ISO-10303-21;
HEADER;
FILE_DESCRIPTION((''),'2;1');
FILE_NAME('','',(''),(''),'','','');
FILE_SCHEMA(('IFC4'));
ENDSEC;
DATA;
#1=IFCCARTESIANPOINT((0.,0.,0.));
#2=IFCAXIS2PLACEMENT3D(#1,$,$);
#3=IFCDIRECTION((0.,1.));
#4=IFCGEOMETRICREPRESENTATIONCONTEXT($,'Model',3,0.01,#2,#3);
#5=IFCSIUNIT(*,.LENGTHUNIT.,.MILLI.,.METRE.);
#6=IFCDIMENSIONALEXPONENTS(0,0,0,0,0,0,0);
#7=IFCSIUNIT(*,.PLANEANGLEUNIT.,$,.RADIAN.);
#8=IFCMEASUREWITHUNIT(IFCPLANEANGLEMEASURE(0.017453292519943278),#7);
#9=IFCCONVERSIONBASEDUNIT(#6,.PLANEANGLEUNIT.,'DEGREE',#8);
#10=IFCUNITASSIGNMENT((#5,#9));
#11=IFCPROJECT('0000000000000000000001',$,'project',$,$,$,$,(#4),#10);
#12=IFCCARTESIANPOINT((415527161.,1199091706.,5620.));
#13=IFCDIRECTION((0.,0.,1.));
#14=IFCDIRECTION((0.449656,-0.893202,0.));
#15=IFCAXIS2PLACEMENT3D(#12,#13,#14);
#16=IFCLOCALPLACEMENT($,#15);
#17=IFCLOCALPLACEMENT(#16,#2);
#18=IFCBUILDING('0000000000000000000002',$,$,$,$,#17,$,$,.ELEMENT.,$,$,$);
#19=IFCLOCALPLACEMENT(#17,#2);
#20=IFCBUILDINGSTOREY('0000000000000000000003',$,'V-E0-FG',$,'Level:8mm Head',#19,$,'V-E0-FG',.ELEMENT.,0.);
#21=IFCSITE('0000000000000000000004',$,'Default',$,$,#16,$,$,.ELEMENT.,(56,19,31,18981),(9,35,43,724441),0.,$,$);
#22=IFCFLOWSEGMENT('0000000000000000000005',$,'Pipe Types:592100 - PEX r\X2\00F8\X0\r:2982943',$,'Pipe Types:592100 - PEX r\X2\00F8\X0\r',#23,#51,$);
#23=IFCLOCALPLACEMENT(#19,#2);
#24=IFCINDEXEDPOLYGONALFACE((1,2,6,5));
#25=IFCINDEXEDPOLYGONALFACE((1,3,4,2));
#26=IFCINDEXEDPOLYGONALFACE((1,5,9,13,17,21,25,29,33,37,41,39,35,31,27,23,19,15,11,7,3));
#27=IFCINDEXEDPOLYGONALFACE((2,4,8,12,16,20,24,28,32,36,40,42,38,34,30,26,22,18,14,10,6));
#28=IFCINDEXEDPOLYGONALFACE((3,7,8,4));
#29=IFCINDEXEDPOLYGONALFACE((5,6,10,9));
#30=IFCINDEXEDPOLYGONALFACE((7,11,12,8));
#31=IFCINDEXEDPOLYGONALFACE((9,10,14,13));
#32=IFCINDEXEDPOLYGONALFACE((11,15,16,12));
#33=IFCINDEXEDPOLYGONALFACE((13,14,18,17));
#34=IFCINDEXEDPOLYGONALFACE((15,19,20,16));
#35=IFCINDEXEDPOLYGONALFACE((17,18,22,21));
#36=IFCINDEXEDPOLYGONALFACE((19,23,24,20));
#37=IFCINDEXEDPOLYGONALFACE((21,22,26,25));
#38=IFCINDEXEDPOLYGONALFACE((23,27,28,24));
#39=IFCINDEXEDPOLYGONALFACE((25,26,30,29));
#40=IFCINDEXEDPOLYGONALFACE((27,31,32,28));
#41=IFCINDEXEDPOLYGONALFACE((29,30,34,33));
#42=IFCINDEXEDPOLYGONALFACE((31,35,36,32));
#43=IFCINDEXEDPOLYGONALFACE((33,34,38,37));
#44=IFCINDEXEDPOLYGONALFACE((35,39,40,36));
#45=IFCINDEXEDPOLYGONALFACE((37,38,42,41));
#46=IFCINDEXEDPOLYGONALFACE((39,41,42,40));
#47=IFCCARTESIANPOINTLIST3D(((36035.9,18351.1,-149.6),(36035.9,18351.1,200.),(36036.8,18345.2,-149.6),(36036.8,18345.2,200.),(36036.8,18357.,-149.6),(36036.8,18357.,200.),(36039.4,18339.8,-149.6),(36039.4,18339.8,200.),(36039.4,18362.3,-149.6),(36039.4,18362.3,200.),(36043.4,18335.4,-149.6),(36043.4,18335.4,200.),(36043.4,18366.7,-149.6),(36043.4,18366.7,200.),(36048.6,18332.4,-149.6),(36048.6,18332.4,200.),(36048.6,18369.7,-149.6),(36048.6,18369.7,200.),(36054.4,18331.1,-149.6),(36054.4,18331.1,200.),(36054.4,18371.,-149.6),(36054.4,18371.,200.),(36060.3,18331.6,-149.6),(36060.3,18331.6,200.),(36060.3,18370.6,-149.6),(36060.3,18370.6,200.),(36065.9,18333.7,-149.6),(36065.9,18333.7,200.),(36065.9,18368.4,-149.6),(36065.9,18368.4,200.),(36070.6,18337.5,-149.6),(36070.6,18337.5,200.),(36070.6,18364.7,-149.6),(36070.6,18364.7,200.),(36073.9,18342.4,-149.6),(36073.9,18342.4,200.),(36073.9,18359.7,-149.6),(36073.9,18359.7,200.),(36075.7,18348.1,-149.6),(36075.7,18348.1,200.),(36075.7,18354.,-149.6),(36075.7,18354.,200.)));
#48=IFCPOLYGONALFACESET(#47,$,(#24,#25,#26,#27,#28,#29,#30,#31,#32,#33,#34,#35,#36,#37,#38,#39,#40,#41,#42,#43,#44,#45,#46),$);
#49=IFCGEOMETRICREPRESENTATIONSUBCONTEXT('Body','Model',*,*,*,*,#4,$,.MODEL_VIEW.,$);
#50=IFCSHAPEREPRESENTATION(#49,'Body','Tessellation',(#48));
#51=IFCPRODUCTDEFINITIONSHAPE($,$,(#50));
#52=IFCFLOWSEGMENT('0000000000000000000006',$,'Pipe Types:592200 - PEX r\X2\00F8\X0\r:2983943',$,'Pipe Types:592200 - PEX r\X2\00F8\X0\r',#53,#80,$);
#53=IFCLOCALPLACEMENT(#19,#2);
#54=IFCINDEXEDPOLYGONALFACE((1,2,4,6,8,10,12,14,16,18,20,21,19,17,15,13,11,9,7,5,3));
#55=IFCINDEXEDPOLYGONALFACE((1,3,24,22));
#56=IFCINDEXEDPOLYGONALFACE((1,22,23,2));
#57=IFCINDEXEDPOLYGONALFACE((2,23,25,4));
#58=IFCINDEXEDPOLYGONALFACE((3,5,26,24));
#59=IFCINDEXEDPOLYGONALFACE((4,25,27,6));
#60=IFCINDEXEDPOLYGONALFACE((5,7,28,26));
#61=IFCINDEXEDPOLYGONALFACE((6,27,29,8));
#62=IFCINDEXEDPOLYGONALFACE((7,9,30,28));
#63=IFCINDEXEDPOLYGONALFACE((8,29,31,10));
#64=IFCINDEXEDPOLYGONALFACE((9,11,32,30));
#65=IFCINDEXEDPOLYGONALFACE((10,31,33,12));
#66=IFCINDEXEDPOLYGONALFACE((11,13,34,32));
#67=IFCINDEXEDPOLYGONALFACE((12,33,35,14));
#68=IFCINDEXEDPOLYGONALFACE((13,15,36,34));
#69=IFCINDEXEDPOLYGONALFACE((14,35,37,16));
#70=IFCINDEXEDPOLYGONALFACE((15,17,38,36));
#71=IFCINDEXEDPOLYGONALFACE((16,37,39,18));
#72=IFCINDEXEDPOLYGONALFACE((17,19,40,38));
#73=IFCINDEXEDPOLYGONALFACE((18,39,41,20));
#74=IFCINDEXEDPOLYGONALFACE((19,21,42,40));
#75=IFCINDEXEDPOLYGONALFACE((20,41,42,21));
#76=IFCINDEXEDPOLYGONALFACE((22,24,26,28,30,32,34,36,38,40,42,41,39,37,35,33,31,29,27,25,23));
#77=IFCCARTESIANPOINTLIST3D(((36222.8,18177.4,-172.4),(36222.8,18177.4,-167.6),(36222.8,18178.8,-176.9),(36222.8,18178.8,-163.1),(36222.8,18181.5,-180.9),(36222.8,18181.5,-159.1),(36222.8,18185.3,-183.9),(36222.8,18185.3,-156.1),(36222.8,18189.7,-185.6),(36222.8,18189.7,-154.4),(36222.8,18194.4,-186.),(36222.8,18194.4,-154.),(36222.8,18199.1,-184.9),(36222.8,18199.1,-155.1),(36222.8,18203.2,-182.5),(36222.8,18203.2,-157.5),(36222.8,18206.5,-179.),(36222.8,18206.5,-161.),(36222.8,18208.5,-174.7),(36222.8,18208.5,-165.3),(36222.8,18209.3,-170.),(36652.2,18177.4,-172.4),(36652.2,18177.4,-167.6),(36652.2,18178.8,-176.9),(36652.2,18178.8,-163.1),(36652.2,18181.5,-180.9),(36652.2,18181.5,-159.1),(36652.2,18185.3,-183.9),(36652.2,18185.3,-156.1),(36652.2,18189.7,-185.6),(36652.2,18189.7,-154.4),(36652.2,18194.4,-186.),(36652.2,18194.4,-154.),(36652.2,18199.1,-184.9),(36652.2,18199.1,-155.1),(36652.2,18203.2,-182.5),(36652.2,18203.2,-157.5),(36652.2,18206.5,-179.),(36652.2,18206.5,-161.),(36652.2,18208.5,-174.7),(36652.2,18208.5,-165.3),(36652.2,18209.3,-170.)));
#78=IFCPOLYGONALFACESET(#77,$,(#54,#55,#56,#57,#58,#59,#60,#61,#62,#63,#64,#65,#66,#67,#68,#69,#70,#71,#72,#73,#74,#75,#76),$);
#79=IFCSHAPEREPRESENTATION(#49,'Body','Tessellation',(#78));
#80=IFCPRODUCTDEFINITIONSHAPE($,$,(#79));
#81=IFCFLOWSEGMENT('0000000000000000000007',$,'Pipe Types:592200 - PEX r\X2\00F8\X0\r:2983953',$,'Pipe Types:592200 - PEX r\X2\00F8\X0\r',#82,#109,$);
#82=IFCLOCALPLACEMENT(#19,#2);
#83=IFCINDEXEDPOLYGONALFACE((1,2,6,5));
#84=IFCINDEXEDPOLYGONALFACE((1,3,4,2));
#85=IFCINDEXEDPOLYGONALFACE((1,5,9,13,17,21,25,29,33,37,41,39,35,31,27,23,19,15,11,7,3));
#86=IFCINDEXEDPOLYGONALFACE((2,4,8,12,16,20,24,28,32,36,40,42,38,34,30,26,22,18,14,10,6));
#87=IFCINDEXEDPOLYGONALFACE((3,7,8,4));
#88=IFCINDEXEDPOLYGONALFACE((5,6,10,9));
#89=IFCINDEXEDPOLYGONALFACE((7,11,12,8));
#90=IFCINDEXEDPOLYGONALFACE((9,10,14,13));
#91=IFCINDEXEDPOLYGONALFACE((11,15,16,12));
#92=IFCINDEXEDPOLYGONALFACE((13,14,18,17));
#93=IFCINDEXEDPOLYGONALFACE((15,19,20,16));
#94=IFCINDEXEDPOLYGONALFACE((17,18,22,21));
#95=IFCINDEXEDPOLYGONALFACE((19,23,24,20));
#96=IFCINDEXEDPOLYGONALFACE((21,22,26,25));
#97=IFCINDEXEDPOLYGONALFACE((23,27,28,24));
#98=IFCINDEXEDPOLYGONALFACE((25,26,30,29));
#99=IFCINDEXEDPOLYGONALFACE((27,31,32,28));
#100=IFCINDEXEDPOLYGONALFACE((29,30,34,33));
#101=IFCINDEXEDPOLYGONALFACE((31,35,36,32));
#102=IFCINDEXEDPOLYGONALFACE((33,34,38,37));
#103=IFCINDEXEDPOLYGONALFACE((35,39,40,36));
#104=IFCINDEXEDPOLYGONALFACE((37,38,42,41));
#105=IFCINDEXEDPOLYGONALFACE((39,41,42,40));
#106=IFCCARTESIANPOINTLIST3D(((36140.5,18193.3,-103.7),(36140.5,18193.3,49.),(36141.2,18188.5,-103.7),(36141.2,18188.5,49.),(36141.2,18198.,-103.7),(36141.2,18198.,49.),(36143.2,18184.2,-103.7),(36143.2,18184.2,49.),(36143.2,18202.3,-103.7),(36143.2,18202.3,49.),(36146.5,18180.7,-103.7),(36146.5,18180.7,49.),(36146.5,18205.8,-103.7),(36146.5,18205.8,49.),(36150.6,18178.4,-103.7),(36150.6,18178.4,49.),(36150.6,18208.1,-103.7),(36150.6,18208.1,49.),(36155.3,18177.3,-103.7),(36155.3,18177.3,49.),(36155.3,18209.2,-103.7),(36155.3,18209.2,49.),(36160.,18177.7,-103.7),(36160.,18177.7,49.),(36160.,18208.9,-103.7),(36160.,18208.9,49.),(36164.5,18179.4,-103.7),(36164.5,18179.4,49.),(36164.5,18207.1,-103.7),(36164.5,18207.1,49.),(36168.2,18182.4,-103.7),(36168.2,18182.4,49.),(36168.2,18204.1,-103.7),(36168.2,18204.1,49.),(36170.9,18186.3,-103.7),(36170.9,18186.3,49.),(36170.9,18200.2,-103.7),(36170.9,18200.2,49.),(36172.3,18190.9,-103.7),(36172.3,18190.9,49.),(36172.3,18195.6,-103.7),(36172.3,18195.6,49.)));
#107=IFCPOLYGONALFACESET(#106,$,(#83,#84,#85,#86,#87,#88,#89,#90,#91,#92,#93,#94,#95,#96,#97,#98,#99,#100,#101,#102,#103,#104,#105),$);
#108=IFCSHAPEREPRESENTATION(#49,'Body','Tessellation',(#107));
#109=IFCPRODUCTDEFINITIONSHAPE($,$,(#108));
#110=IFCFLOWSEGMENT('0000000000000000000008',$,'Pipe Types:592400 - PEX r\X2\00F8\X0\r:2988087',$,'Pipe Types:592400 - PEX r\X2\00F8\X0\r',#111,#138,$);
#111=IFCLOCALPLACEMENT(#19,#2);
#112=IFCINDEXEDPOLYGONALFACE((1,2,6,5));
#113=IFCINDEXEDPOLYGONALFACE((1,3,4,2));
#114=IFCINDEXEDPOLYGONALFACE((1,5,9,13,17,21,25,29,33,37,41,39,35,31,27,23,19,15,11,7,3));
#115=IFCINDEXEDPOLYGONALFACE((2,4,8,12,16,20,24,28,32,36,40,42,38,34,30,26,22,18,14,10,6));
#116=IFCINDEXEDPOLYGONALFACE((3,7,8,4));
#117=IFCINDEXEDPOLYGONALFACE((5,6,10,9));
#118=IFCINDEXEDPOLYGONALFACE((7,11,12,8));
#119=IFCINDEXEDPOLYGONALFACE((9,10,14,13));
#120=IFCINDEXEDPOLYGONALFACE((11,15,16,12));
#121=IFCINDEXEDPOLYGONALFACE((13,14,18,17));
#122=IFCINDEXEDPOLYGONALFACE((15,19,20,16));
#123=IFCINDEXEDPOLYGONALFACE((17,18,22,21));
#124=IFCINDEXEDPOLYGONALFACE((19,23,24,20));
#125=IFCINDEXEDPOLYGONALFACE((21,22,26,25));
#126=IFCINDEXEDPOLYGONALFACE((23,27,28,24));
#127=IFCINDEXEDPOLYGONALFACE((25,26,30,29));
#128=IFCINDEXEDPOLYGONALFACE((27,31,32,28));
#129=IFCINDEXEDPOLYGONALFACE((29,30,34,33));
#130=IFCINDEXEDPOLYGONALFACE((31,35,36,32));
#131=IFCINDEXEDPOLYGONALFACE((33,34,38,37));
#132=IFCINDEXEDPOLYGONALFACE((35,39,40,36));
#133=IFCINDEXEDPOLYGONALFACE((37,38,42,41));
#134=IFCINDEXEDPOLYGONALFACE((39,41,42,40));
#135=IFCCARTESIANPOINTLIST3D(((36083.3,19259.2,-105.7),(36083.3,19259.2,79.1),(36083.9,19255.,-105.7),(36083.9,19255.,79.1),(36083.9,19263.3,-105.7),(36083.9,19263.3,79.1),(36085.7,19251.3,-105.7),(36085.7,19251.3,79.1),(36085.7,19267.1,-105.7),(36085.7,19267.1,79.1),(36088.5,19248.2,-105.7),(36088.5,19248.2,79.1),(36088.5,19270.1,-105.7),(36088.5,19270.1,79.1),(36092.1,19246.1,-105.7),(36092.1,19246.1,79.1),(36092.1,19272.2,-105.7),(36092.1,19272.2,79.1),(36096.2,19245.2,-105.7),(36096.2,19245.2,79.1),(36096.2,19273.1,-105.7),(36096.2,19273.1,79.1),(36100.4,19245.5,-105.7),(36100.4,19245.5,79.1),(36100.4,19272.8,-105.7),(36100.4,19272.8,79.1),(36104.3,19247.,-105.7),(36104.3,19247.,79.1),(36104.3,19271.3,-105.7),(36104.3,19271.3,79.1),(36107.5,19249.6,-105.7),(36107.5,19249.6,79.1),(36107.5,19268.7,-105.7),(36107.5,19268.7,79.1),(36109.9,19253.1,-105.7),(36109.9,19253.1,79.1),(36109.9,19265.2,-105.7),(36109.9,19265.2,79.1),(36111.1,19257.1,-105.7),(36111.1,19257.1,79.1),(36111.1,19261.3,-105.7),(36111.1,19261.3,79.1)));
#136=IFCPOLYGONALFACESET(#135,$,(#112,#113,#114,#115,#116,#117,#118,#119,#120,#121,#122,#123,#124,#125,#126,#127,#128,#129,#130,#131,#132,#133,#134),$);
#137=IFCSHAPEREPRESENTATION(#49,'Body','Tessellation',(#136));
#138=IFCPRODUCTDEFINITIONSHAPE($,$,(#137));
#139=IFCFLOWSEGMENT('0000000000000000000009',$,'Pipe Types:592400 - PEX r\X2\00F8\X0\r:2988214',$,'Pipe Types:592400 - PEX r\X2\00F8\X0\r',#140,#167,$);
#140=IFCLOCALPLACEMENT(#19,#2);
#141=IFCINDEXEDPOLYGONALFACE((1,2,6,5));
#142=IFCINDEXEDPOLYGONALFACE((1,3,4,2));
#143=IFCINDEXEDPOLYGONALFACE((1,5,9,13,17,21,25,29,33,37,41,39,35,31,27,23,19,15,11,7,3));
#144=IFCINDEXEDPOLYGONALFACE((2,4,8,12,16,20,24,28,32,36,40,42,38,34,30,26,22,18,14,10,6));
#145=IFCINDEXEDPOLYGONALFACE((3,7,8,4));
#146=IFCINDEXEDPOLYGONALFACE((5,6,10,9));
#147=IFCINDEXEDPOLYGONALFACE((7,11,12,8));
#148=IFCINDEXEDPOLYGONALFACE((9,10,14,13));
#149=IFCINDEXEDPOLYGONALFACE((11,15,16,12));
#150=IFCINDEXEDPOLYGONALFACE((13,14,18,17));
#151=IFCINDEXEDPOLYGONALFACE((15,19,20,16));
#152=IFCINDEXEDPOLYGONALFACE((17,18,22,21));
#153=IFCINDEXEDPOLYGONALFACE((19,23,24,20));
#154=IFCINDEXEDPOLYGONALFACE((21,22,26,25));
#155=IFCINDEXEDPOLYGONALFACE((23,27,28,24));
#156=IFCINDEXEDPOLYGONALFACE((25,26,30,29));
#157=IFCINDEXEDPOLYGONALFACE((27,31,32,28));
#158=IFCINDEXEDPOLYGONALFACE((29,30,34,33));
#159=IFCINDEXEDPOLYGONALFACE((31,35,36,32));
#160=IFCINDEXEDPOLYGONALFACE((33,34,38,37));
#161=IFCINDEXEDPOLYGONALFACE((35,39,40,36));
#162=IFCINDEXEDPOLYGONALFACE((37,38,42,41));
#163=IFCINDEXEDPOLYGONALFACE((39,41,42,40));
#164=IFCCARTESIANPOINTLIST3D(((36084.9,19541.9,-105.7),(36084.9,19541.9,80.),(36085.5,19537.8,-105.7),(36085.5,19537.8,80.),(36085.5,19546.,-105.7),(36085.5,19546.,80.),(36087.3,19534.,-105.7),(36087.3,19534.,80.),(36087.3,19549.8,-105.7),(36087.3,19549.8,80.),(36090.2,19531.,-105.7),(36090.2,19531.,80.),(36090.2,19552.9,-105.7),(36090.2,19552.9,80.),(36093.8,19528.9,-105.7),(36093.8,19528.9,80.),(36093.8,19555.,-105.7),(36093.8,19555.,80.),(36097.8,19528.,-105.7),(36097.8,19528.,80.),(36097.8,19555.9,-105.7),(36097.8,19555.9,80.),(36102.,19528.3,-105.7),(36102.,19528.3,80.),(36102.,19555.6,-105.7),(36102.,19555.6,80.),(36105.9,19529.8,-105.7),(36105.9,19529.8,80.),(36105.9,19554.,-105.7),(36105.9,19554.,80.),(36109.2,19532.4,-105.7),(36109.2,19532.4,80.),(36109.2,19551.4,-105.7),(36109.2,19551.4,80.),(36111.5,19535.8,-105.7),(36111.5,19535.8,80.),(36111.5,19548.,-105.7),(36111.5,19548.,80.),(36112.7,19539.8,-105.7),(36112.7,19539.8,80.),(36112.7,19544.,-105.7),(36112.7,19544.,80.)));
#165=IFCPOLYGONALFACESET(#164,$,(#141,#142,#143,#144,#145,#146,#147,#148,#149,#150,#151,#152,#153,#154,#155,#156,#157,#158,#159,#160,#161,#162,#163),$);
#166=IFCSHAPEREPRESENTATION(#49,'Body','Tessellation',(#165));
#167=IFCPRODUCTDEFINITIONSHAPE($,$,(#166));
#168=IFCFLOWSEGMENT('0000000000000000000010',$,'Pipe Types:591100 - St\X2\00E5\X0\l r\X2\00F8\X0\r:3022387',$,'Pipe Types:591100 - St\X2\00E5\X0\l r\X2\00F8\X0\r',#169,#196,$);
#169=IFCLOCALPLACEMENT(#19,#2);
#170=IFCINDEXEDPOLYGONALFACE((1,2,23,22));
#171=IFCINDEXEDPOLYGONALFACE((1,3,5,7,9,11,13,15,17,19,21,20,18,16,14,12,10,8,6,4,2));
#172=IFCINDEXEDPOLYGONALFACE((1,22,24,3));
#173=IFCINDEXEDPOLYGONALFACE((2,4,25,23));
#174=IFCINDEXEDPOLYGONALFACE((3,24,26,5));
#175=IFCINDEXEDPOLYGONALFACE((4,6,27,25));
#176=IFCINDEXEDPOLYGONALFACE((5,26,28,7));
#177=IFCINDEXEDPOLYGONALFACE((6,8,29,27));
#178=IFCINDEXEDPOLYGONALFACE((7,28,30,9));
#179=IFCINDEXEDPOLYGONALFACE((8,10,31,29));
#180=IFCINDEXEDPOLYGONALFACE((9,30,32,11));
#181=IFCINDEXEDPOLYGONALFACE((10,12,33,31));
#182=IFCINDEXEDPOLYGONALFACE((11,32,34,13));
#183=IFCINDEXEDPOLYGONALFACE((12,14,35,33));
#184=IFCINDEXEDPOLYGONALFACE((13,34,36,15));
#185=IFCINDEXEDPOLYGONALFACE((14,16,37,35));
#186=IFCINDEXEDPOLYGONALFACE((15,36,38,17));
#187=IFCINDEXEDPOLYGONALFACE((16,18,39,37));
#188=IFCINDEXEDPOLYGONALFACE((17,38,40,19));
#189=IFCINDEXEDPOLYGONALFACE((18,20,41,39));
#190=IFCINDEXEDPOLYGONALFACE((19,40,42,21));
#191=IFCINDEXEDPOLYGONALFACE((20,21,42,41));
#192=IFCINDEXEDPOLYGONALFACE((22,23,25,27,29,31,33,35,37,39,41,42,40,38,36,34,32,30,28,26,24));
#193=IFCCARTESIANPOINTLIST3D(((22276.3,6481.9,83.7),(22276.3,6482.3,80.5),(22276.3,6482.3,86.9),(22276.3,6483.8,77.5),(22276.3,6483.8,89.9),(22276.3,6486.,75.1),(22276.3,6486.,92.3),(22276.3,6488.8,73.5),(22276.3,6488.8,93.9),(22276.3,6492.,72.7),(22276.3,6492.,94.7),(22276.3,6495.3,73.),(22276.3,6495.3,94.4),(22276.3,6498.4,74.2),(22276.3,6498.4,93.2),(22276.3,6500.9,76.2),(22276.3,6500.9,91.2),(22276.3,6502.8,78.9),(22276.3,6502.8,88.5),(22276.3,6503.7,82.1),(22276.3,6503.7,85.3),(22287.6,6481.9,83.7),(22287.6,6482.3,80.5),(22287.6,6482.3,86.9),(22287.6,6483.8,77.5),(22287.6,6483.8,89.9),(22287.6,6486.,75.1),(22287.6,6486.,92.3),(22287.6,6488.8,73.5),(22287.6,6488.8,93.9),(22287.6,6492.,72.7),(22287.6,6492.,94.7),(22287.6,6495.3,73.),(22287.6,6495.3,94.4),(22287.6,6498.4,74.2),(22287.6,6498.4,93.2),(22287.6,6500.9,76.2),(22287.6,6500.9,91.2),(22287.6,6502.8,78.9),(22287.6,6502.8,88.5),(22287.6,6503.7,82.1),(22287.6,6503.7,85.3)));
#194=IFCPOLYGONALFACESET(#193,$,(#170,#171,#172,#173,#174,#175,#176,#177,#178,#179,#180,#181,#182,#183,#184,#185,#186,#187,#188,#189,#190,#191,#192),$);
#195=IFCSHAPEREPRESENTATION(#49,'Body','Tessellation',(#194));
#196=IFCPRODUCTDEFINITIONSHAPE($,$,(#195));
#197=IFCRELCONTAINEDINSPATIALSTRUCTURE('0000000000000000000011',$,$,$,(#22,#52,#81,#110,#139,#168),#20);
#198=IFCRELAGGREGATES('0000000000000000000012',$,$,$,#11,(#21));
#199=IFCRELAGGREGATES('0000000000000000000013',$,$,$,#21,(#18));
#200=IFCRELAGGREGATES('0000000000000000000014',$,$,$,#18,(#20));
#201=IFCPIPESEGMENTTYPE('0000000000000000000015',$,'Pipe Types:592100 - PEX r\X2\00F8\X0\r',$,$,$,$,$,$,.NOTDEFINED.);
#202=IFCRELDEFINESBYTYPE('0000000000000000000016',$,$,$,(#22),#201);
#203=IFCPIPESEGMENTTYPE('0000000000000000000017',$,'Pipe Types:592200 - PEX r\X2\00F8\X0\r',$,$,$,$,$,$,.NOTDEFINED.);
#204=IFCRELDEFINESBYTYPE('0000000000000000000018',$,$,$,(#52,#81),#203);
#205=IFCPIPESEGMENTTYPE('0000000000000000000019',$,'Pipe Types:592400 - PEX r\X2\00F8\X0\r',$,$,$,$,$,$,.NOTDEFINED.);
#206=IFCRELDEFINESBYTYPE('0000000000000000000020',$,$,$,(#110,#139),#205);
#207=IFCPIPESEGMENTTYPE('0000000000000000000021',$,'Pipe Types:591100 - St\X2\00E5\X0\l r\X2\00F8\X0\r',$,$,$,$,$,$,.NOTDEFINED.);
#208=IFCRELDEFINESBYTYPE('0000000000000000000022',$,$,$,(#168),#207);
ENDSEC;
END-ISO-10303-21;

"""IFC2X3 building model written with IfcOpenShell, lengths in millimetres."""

from ifc_helpers import new_model, entity, si_unit, converted_unit, direction, frame, frame_2d, origin, origin_2d_with_axis, place, context, subcontext, project, spatial, circle, extrude, type_object, element, save


model = new_model("IFC2X3")

# Units and contexts
model_context = context("Model", 3, precision=0.01, world=origin(), true_north=direction((0.0, 1.0)))
body_context = subcontext(model_context, "Body", "Model", "MODEL_VIEW")
ifc_project = project(units=[si_unit("LENGTHUNIT", "METRE", prefix="MILLI"), converted_unit("PLANEANGLEUNIT", "DEGREE", entity("IfcPlaneAngleMeasure", 0.017453292519943278), si_unit("PLANEANGLEUNIT", "RADIAN"), dimensions=[0, 0, 0, 0, 0, 0, 0])], contexts=[model_context])

# Site, building, storey
site_placement = place(None, frame((415527161.0, 1199091706.0, 5620.0), z_axis=(0.0, 0.0, 1.0), x_axis=(0.449656, -0.893202, 0.0)))
site = spatial("IfcSite", under=ifc_project, at=site_placement, Name="Default", CompositionType="ELEMENT", RefLatitude=(56, 19, 31, 18981), RefLongitude=(9, 35, 43, 724441), RefElevation=0.0)
building_placement = place(site_placement, origin())
building = spatial("IfcBuilding", under=site, at=building_placement, CompositionType="ELEMENT")
storey_placement = place(building_placement, origin())
storey = spatial("IfcBuildingStorey", under=building, at=storey_placement, Name="V-E0-FG", ObjectType="Level:8mm Head", LongName="V-E0-FG", CompositionType="ELEMENT", Elevation=0.0)

# Flow segments
pipe_segment_type_1 = type_object("IfcPipeSegmentType", Name="Pipe Types:592100 - PEX rør", PredefinedType="NOTDEFINED")
flow_segment_1_placement = place(storey_placement, origin())
element("IfcFlowSegment", 1, at=flow_segment_1_placement, inside=storey, type_object=pipe_segment_type_1, Name="Pipe Types:592100 - PEX rør:2982943", ObjectType="Pipe Types:592100 - PEX rør", context=body_context, shape_type="SweptSolid", body=[
    extrude(circle(Radius=20.0, at=origin_2d_with_axis()), frame((36055.9, 18351.1, -149.6), z_axis=(0.0, 0.0, 1.0), x_axis=(-1.0, 0.0, 0.0)), (0.0, 0.0, 1.0), 349.6),
])
pipe_segment_type_2 = type_object("IfcPipeSegmentType", Name="Pipe Types:592200 - PEX rør", PredefinedType="NOTDEFINED")
flow_segment_2_placement = place(storey_placement, origin())
element("IfcFlowSegment", 2, at=flow_segment_2_placement, inside=storey, type_object=pipe_segment_type_2, Name="Pipe Types:592200 - PEX rør:2983943", ObjectType="Pipe Types:592200 - PEX rør", context=body_context, shape_type="SweptSolid", body=[
    extrude(circle(Radius=16.0, at=frame_2d((0.0, 0.0), x_axis=(1.0, 0.0))), frame((36222.8, 18193.3, -170.0), z_axis=(1.0, 0.0, 0.0), x_axis=(0.0, 1.0, 0.0)), (0.0, 0.0, 1.0), 429.5),
])
flow_segment_3_placement = place(storey_placement, origin())
element("IfcFlowSegment", 3, at=flow_segment_3_placement, inside=storey, type_object=pipe_segment_type_2, Name="Pipe Types:592200 - PEX rør:2983953", ObjectType="Pipe Types:592200 - PEX rør", context=body_context, shape_type="SweptSolid", body=[
    extrude(circle(Radius=16.0, at=origin_2d_with_axis()), frame((36156.5, 18193.3, -103.7), z_axis=(0.0, 0.0, 1.0), x_axis=(-1.0, 0.0, 0.0)), (0.0, 0.0, 1.0), 152.7),
])
pipe_segment_type_3 = type_object("IfcPipeSegmentType", Name="Pipe Types:592400 - PEX rør", PredefinedType="NOTDEFINED")
flow_segment_4_placement = place(storey_placement, origin())
element("IfcFlowSegment", 4, at=flow_segment_4_placement, inside=storey, type_object=pipe_segment_type_3, Name="Pipe Types:592400 - PEX rør:2988087", ObjectType="Pipe Types:592400 - PEX rør", context=body_context, shape_type="SweptSolid", body=[
    extrude(circle(Radius=14.0, at=origin_2d_with_axis()), frame((36097.3, 19259.2, -105.7), z_axis=(0.0, 0.0, 1.0), x_axis=(-1.0, 0.0, 0.0)), (0.0, 0.0, 1.0), 184.8),
])
flow_segment_5_placement = place(storey_placement, origin())
element("IfcFlowSegment", 5, at=flow_segment_5_placement, inside=storey, type_object=pipe_segment_type_3, Name="Pipe Types:592400 - PEX rør:2988214", ObjectType="Pipe Types:592400 - PEX rør", context=body_context, shape_type="SweptSolid", body=[
    extrude(circle(Radius=14.0, at=origin_2d_with_axis()), frame((36098.9, 19541.9, -105.7), z_axis=(0.0, 0.0, 1.0), x_axis=(-1.0, 0.0, 0.0)), (0.0, 0.0, 1.0), 185.7),
])
pipe_segment_type_4 = type_object("IfcPipeSegmentType", Name="Pipe Types:591100 - Stål rør", PredefinedType="NOTDEFINED")
flow_segment_6_placement = place(storey_placement, origin())
element("IfcFlowSegment", 6, at=flow_segment_6_placement, inside=storey, type_object=pipe_segment_type_4, Name="Pipe Types:591100 - Stål rør:3022387", ObjectType="Pipe Types:591100 - Stål rør", context=body_context, shape_type="SweptSolid", body=[
    extrude(circle(Radius=11.0, at=origin_2d_with_axis()), frame((22276.3, 6492.9, 83.7), z_axis=(1.0, -0.000012, 0.0), x_axis=(-0.000012, -1.0, 0.0)), (0.0, 0.0, 1.0), 11.3),
])

save(model, "model.ifc")
